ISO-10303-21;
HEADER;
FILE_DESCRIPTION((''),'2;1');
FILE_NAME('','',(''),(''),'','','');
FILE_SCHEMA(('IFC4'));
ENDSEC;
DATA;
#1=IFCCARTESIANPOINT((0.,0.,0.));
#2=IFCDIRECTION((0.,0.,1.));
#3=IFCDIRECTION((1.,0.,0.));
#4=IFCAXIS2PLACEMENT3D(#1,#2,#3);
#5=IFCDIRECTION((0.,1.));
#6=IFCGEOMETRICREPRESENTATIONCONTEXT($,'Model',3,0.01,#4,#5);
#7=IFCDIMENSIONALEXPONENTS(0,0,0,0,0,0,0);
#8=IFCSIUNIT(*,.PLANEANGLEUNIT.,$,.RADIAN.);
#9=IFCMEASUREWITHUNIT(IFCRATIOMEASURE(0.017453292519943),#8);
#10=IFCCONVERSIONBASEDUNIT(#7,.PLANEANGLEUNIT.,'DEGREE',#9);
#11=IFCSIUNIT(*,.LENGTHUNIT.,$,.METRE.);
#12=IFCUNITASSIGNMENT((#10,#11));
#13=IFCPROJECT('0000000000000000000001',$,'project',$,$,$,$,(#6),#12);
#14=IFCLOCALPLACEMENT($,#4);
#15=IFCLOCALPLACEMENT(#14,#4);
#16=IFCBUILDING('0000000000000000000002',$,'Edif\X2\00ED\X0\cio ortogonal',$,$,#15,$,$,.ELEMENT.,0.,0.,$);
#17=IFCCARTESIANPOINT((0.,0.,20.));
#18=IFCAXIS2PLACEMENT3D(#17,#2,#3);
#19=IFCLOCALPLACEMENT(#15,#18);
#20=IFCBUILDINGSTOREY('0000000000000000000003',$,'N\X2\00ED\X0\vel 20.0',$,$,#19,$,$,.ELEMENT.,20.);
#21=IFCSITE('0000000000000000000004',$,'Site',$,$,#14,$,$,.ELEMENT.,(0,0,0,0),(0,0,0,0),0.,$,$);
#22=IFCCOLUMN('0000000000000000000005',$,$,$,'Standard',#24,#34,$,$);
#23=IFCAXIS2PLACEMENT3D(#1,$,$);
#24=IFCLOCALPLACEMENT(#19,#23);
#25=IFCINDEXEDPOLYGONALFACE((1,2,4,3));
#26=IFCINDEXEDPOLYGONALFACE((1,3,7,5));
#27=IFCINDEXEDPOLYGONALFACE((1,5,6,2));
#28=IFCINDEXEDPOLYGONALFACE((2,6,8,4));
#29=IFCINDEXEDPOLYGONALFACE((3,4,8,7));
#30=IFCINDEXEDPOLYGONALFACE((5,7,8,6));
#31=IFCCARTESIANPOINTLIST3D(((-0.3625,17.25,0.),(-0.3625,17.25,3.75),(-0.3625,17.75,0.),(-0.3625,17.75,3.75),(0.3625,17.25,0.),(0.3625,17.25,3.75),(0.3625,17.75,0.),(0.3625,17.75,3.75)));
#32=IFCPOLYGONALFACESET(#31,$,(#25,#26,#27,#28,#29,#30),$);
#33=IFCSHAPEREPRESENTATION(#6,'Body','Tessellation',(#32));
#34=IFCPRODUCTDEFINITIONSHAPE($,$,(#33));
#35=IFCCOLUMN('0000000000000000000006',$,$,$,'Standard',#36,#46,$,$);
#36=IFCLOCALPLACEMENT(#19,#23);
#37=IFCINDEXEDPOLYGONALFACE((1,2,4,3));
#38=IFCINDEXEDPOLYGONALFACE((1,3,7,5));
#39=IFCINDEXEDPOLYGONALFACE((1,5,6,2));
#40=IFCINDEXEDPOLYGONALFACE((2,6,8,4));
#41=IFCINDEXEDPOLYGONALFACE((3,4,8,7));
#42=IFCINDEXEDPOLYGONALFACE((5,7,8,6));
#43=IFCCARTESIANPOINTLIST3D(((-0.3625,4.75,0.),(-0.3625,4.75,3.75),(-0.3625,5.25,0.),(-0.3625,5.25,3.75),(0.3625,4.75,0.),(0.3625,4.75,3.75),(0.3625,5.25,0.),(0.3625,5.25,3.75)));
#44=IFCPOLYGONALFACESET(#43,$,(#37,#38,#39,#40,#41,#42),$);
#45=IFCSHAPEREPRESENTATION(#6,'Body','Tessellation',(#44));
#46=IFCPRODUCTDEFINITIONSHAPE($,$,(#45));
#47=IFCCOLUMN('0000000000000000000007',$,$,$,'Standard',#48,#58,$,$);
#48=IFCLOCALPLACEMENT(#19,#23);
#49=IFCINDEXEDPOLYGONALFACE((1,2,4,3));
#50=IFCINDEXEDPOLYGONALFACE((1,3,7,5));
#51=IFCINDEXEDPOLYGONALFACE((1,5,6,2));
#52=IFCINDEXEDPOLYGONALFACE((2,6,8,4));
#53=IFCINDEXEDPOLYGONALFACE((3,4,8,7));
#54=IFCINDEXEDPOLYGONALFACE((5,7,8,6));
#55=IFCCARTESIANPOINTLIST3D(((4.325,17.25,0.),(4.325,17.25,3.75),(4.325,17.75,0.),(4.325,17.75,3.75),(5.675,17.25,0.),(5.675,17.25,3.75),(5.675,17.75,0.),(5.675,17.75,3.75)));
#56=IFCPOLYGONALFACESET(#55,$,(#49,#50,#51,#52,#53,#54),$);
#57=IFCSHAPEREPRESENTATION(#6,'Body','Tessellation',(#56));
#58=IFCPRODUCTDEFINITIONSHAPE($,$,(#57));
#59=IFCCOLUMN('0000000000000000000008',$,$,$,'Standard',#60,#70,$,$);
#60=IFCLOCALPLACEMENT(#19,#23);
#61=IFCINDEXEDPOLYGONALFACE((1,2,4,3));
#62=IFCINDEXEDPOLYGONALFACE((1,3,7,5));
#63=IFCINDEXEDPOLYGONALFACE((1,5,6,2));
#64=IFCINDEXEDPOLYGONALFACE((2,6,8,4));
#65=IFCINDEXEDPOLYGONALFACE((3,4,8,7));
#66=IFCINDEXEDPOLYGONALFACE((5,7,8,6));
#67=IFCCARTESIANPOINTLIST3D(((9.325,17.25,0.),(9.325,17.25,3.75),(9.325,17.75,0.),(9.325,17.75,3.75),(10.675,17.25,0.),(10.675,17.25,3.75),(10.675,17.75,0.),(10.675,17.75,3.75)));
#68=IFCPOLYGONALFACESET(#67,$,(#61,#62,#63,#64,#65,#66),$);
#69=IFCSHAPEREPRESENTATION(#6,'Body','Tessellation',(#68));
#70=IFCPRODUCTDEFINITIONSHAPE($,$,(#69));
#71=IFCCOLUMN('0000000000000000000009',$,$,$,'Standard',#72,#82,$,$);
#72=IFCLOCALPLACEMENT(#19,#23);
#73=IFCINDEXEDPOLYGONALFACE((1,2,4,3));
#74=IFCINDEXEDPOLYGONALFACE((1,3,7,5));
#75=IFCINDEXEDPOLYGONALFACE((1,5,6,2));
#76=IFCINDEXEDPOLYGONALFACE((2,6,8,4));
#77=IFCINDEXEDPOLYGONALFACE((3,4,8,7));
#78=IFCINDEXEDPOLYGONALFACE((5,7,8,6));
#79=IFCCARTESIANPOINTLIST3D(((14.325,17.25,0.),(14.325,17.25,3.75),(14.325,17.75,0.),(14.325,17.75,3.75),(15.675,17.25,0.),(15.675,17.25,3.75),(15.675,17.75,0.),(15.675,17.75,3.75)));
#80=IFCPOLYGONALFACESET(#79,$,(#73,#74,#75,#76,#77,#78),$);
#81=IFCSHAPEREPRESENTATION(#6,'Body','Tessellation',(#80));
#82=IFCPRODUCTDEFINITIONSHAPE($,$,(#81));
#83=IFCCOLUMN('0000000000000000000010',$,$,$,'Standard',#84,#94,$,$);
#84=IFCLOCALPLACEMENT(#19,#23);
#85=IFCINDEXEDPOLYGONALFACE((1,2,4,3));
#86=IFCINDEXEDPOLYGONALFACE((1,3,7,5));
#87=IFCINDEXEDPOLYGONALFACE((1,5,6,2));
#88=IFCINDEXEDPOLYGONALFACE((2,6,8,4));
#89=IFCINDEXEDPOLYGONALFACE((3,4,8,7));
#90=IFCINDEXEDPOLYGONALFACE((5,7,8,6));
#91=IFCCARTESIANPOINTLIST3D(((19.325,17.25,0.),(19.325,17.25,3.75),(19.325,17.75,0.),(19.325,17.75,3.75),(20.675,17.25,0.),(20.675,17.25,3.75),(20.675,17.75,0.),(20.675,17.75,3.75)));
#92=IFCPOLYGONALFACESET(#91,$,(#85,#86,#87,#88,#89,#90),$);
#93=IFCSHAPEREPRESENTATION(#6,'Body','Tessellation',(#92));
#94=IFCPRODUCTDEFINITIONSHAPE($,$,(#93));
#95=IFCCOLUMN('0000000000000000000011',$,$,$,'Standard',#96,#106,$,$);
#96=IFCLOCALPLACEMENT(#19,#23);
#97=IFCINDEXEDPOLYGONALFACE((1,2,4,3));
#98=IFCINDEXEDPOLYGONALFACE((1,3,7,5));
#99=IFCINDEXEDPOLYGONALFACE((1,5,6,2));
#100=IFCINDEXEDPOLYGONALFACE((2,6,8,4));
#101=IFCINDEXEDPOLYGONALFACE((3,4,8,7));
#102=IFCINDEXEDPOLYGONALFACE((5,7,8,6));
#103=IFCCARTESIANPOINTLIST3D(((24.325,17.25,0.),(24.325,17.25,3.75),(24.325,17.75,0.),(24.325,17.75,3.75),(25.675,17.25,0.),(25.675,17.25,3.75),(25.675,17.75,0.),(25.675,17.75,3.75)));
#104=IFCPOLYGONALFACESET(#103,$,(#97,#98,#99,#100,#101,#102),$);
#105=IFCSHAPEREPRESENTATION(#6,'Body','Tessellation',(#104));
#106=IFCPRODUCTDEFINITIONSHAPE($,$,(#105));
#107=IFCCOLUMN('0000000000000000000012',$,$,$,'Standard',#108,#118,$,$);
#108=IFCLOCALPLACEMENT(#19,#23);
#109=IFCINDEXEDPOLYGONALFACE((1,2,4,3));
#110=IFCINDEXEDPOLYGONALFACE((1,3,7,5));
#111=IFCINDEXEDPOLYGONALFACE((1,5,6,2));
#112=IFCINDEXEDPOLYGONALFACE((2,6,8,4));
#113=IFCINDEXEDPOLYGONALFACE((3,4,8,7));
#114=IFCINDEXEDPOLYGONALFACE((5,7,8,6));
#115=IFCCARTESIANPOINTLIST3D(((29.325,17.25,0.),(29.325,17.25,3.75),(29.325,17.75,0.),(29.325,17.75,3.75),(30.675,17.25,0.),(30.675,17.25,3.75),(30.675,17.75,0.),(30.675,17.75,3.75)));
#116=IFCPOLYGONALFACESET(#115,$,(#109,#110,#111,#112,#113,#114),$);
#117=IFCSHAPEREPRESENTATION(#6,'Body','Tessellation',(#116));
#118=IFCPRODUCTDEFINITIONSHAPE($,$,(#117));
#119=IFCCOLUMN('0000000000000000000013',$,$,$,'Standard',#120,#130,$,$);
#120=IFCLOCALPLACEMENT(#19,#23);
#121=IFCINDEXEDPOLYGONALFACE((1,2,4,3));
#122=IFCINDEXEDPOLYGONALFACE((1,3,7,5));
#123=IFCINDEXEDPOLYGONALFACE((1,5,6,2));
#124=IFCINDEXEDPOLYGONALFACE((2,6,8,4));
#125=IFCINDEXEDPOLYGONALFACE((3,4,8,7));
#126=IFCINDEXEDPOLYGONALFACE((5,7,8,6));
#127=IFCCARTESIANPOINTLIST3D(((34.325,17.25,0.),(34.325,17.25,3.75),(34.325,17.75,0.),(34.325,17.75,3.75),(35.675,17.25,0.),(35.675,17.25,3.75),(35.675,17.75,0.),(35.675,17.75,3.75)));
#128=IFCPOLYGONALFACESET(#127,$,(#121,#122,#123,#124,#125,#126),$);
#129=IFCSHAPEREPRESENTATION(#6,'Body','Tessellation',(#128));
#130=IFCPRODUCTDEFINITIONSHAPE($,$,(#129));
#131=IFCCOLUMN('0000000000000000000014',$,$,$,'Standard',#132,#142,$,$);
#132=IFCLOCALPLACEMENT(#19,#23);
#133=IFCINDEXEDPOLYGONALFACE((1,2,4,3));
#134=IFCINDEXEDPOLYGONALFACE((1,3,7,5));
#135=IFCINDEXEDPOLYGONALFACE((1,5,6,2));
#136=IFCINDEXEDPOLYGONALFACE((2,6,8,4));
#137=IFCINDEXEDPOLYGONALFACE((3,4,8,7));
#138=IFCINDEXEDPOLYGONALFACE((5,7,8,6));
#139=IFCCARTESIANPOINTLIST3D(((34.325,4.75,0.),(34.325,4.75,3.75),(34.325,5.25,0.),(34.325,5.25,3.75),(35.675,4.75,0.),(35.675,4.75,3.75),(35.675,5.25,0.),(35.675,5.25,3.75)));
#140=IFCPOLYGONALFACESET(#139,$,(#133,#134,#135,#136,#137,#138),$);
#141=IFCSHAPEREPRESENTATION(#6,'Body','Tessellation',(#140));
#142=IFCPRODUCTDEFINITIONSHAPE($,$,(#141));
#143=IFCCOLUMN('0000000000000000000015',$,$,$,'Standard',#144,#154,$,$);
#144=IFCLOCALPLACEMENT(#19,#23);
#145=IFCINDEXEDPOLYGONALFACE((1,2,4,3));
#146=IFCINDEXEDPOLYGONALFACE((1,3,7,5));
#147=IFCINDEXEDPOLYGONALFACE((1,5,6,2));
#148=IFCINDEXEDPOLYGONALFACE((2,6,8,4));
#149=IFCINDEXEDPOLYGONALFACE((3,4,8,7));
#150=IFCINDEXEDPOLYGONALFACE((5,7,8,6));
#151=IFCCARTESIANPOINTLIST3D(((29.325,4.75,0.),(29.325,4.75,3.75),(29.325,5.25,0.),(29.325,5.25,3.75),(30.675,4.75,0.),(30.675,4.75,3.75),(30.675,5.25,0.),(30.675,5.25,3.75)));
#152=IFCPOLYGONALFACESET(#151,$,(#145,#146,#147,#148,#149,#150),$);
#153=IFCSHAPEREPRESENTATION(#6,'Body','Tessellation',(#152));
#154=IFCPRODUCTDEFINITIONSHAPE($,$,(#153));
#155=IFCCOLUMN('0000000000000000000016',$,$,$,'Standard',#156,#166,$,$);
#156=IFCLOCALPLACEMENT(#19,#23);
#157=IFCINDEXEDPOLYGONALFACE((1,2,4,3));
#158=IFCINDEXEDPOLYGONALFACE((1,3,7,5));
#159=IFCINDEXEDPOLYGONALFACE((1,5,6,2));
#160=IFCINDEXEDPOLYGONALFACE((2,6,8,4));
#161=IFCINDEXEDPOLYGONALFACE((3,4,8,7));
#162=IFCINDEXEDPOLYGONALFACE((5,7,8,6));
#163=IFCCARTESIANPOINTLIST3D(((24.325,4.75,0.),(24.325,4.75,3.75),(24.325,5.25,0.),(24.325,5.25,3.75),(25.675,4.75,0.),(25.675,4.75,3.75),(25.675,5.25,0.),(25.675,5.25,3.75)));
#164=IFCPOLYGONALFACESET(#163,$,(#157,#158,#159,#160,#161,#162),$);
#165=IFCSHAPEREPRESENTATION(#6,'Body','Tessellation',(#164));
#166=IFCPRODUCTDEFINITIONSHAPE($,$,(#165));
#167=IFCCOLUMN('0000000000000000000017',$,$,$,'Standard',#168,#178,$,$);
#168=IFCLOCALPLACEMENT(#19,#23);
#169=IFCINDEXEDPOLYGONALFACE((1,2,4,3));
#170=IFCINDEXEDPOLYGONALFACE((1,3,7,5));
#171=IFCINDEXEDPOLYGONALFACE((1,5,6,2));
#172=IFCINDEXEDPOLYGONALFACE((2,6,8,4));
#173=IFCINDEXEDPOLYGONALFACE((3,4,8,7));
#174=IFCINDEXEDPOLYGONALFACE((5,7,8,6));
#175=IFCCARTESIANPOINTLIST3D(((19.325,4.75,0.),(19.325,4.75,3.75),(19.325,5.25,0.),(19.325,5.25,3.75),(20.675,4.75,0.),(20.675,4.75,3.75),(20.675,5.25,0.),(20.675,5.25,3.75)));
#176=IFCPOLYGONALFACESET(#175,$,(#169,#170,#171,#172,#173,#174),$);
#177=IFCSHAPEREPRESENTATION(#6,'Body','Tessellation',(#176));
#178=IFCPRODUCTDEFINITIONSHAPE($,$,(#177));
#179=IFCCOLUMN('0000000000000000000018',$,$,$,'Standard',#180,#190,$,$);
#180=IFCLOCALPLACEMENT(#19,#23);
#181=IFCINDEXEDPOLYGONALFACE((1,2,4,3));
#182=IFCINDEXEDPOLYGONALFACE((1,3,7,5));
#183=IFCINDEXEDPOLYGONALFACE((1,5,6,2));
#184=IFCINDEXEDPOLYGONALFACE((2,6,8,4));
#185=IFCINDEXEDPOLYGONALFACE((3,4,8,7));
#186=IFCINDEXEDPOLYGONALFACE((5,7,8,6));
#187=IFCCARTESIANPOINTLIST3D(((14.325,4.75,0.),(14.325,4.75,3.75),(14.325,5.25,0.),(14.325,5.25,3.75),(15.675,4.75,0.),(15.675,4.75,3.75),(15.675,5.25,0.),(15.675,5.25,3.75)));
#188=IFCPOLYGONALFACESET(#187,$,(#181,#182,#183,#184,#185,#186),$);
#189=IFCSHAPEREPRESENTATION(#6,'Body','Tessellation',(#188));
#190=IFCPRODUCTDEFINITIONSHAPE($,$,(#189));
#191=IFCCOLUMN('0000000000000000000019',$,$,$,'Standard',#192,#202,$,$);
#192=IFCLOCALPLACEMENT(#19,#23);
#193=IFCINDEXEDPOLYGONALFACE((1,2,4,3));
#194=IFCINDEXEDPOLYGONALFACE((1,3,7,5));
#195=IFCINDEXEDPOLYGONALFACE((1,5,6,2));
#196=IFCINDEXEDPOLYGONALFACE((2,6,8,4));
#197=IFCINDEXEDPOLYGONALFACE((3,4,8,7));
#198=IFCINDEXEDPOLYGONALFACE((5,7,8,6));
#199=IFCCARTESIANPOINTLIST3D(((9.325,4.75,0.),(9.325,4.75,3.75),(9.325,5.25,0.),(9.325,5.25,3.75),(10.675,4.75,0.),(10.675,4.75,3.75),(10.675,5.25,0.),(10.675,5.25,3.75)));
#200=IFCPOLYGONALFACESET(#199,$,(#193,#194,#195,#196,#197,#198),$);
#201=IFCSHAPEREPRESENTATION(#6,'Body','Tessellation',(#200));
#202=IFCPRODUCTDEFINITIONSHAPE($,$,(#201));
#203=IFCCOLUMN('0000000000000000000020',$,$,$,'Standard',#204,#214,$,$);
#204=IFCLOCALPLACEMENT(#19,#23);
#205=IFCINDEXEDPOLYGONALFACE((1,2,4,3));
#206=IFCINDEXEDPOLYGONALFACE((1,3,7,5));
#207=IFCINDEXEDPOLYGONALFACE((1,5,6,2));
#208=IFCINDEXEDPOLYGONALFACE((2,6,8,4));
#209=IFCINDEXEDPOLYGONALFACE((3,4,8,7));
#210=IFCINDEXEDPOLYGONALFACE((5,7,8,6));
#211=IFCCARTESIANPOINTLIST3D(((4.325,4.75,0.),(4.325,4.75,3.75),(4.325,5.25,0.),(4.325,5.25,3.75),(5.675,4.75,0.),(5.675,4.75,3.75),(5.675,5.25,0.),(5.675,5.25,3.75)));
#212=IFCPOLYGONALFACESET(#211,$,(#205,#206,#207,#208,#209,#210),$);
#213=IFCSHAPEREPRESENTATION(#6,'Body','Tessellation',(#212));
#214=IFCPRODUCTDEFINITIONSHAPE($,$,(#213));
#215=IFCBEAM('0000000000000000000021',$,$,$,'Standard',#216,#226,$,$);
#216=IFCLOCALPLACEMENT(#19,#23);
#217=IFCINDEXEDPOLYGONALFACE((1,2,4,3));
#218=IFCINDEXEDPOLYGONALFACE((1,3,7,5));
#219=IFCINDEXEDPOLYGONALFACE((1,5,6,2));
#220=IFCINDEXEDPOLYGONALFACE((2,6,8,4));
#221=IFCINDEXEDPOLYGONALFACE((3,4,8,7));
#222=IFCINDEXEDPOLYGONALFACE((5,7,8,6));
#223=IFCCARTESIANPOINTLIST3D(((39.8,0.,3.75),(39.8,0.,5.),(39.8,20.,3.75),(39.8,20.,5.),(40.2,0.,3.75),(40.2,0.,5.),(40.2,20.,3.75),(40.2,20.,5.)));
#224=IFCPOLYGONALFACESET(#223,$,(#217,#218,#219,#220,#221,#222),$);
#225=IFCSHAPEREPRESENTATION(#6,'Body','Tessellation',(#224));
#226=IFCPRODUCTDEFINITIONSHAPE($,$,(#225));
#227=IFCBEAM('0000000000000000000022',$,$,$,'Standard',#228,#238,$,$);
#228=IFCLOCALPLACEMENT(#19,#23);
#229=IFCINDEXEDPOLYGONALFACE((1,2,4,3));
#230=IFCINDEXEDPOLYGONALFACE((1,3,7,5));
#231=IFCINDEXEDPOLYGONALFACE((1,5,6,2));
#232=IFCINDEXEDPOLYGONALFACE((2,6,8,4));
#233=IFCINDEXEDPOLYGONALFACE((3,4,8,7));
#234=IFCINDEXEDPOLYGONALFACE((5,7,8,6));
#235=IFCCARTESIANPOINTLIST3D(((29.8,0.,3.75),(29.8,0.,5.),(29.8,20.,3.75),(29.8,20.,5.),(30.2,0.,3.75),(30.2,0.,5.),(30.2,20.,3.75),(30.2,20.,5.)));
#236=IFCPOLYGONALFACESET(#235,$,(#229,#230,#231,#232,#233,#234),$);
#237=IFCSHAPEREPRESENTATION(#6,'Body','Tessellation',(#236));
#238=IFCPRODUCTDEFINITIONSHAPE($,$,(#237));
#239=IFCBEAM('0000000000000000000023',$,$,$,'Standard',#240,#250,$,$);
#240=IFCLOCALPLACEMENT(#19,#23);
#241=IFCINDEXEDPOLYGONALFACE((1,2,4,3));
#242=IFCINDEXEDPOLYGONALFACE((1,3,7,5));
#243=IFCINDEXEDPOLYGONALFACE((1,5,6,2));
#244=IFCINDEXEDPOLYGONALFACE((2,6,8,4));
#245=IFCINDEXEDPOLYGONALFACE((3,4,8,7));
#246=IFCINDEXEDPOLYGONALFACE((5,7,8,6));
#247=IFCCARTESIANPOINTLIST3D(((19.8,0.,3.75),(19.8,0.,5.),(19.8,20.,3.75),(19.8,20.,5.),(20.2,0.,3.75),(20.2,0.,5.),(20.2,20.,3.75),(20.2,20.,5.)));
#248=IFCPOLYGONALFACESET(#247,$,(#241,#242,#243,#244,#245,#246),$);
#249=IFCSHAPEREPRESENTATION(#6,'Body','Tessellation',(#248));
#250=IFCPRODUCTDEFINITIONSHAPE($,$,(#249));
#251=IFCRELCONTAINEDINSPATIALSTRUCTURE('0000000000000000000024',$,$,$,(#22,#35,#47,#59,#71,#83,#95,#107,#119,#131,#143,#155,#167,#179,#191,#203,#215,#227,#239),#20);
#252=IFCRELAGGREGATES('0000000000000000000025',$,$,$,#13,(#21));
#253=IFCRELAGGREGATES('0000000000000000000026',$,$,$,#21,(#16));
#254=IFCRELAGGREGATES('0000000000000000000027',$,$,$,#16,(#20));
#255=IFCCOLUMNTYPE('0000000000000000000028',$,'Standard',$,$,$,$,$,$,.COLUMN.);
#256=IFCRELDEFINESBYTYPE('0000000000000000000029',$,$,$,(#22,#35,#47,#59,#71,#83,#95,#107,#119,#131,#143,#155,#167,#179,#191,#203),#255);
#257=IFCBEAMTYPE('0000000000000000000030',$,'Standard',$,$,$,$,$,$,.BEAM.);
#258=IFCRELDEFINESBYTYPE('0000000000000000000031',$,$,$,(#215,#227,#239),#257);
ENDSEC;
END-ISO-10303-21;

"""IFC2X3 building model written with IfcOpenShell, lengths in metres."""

from ifc_helpers import new_model, entity, si_unit, converted_unit, direction, frame, origin_with_axes, origin_2d, place, context, project, spatial, polyline, rectangle, outline, extrude, type_object, element, save


model = new_model("IFC2X3")

# Units and contexts
model_context = context("Model", 3, precision=0.01, world=origin_with_axes(), true_north=direction((0.0, 1.0)))
ifc_project = project(units=[converted_unit("PLANEANGLEUNIT", "DEGREE", entity("IfcRatioMeasure", 0.017453292519943), si_unit("PLANEANGLEUNIT", "RADIAN"), dimensions=[0, 0, 0, 0, 0, 0, 0]), si_unit("LENGTHUNIT", "METRE")], contexts=[model_context])

# Site, building, storey
site_placement = place(None, origin_with_axes())
site = spatial("IfcSite", under=ifc_project, at=site_placement, Name="Site", CompositionType="ELEMENT", RefLatitude=(0, 0, 0, 0), RefLongitude=(0, 0, 0, 0), RefElevation=0.0)
building_placement = place(site_placement, origin_with_axes())
building = spatial("IfcBuilding", under=site, at=building_placement, Name="Edifício ortogonal", CompositionType="ELEMENT", ElevationOfRefHeight=0.0, ElevationOfTerrain=0.0)
storey_placement = place(building_placement, frame((0.0, 0.0, 20.0), z_axis=(0.0, 0.0, 1.0), x_axis=(1.0, 0.0, 0.0)))
storey = spatial("IfcBuildingStorey", under=building, at=storey_placement, Name="Nível 20.0", CompositionType="ELEMENT", Elevation=20.0)

# Columns
column_type = type_object("IfcColumnType", Name="Standard", PredefinedType="COLUMN")
for number, where, z_axis, x_axis in (
    (1, (0.0, 17.5, 20.0), (0.0, 0.0, 1.0), (1.0, 0.0, 0.0)),
    (2, (0.0, 5.0, 20.0), (0.0, 0.0, 1.0), (1.0, 0.0, 0.0)),
):
    element("IfcColumn", number, at=place(site_placement, frame(where, z_axis=z_axis, x_axis=x_axis)), inside=storey, type_object=column_type, ObjectType="Standard", context=model_context, shape_type="SweptSolid", body=[
        extrude(outline(polyline([(0.3625, -0.25), (0.3625, 0.25), (-0.3625, 0.25), (-0.3625, -0.25), (0.3625, -0.25)])), origin_with_axes(), (0.0, 0.0, 1.0), 3.75),
    ])
for number, where, z_axis, x_axis in (
    (3, (5.0, 17.5, 20.0), (0.0, 0.0, 1.0), (1.0, 0.0, 0.0)),
    (4, (10.0, 17.5, 20.0), (0.0, 0.0, 1.0), (1.0, 0.0, 0.0)),
    (5, (15.0, 17.5, 20.0), (0.0, 0.0, 1.0), (1.0, 0.0, 0.0)),
    (6, (20.0, 17.5, 20.0), (0.0, 0.0, 1.0), (1.0, 0.0, 0.0)),
    (7, (25.0, 17.5, 20.0), (0.0, 0.0, 1.0), (1.0, 0.0, 0.0)),
    (8, (30.0, 17.5, 20.0), (0.0, 0.0, 1.0), (1.0, 0.0, 0.0)),
    (9, (35.0, 17.5, 20.0), (0.0, 0.0, 1.0), (1.0, 0.0, 0.0)),
    (10, (35.0, 5.0, 20.0), (0.0, 0.0, 1.0), (1.0, 0.0, 0.0)),
    (11, (30.0, 5.0, 20.0), (0.0, 0.0, 1.0), (1.0, 0.0, 0.0)),
    (12, (25.0, 5.0, 20.0), (0.0, 0.0, 1.0), (1.0, 0.0, 0.0)),
    (13, (20.0, 5.0, 20.0), (0.0, 0.0, 1.0), (1.0, 0.0, 0.0)),
    (14, (15.0, 5.0, 20.0), (0.0, 0.0, 1.0), (1.0, 0.0, 0.0)),
    (15, (10.0, 5.0, 20.0), (0.0, 0.0, 1.0), (1.0, 0.0, 0.0)),
    (16, (5.0, 5.0, 20.0), (0.0, 0.0, 1.0), (1.0, 0.0, 0.0)),
):
    element("IfcColumn", number, at=place(site_placement, frame(where, z_axis=z_axis, x_axis=x_axis)), inside=storey, type_object=column_type, ObjectType="Standard", context=model_context, shape_type="SweptSolid", body=[
        extrude(outline(polyline([(0.675, -0.25), (0.675, 0.25), (-0.675, 0.25), (-0.675, -0.25), (0.675, -0.25)])), origin_with_axes(), (0.0, 0.0, 1.0), 3.75),
    ])

# Beams
beam_type = type_object("IfcBeamType", Name="Standard", PredefinedType="BEAM")
for number, where, z_axis, x_axis in (
    (17, (40.0, 20.0, 25.0), (0.0, 0.0, 1.0), (0.0, -1.0, 0.0)),
    (18, (30.0, 20.0, 25.0), (0.0, 0.0, 1.0), (0.0, -1.0, 0.0)),
    (19, (20.0, 20.0, 25.0), (0.0, 0.0, 1.0), (0.0, -1.0, 0.0)),
):
    element("IfcBeam", number, at=place(site_placement, frame(where, z_axis=z_axis, x_axis=x_axis)), inside=storey, type_object=beam_type, ObjectType="Standard", context=model_context, shape_type="SweptSolid", body=[
        extrude(rectangle(XDim=0.4, YDim=1.25, at=origin_2d()), frame((0.0, 0.0, -0.625), z_axis=(1.0, 0.0, 0.0), x_axis=(0.0, 1.0, 0.0)), (0.0, 0.0, 1.0), 20.0),
    ])

save(model, "model.ifc")
